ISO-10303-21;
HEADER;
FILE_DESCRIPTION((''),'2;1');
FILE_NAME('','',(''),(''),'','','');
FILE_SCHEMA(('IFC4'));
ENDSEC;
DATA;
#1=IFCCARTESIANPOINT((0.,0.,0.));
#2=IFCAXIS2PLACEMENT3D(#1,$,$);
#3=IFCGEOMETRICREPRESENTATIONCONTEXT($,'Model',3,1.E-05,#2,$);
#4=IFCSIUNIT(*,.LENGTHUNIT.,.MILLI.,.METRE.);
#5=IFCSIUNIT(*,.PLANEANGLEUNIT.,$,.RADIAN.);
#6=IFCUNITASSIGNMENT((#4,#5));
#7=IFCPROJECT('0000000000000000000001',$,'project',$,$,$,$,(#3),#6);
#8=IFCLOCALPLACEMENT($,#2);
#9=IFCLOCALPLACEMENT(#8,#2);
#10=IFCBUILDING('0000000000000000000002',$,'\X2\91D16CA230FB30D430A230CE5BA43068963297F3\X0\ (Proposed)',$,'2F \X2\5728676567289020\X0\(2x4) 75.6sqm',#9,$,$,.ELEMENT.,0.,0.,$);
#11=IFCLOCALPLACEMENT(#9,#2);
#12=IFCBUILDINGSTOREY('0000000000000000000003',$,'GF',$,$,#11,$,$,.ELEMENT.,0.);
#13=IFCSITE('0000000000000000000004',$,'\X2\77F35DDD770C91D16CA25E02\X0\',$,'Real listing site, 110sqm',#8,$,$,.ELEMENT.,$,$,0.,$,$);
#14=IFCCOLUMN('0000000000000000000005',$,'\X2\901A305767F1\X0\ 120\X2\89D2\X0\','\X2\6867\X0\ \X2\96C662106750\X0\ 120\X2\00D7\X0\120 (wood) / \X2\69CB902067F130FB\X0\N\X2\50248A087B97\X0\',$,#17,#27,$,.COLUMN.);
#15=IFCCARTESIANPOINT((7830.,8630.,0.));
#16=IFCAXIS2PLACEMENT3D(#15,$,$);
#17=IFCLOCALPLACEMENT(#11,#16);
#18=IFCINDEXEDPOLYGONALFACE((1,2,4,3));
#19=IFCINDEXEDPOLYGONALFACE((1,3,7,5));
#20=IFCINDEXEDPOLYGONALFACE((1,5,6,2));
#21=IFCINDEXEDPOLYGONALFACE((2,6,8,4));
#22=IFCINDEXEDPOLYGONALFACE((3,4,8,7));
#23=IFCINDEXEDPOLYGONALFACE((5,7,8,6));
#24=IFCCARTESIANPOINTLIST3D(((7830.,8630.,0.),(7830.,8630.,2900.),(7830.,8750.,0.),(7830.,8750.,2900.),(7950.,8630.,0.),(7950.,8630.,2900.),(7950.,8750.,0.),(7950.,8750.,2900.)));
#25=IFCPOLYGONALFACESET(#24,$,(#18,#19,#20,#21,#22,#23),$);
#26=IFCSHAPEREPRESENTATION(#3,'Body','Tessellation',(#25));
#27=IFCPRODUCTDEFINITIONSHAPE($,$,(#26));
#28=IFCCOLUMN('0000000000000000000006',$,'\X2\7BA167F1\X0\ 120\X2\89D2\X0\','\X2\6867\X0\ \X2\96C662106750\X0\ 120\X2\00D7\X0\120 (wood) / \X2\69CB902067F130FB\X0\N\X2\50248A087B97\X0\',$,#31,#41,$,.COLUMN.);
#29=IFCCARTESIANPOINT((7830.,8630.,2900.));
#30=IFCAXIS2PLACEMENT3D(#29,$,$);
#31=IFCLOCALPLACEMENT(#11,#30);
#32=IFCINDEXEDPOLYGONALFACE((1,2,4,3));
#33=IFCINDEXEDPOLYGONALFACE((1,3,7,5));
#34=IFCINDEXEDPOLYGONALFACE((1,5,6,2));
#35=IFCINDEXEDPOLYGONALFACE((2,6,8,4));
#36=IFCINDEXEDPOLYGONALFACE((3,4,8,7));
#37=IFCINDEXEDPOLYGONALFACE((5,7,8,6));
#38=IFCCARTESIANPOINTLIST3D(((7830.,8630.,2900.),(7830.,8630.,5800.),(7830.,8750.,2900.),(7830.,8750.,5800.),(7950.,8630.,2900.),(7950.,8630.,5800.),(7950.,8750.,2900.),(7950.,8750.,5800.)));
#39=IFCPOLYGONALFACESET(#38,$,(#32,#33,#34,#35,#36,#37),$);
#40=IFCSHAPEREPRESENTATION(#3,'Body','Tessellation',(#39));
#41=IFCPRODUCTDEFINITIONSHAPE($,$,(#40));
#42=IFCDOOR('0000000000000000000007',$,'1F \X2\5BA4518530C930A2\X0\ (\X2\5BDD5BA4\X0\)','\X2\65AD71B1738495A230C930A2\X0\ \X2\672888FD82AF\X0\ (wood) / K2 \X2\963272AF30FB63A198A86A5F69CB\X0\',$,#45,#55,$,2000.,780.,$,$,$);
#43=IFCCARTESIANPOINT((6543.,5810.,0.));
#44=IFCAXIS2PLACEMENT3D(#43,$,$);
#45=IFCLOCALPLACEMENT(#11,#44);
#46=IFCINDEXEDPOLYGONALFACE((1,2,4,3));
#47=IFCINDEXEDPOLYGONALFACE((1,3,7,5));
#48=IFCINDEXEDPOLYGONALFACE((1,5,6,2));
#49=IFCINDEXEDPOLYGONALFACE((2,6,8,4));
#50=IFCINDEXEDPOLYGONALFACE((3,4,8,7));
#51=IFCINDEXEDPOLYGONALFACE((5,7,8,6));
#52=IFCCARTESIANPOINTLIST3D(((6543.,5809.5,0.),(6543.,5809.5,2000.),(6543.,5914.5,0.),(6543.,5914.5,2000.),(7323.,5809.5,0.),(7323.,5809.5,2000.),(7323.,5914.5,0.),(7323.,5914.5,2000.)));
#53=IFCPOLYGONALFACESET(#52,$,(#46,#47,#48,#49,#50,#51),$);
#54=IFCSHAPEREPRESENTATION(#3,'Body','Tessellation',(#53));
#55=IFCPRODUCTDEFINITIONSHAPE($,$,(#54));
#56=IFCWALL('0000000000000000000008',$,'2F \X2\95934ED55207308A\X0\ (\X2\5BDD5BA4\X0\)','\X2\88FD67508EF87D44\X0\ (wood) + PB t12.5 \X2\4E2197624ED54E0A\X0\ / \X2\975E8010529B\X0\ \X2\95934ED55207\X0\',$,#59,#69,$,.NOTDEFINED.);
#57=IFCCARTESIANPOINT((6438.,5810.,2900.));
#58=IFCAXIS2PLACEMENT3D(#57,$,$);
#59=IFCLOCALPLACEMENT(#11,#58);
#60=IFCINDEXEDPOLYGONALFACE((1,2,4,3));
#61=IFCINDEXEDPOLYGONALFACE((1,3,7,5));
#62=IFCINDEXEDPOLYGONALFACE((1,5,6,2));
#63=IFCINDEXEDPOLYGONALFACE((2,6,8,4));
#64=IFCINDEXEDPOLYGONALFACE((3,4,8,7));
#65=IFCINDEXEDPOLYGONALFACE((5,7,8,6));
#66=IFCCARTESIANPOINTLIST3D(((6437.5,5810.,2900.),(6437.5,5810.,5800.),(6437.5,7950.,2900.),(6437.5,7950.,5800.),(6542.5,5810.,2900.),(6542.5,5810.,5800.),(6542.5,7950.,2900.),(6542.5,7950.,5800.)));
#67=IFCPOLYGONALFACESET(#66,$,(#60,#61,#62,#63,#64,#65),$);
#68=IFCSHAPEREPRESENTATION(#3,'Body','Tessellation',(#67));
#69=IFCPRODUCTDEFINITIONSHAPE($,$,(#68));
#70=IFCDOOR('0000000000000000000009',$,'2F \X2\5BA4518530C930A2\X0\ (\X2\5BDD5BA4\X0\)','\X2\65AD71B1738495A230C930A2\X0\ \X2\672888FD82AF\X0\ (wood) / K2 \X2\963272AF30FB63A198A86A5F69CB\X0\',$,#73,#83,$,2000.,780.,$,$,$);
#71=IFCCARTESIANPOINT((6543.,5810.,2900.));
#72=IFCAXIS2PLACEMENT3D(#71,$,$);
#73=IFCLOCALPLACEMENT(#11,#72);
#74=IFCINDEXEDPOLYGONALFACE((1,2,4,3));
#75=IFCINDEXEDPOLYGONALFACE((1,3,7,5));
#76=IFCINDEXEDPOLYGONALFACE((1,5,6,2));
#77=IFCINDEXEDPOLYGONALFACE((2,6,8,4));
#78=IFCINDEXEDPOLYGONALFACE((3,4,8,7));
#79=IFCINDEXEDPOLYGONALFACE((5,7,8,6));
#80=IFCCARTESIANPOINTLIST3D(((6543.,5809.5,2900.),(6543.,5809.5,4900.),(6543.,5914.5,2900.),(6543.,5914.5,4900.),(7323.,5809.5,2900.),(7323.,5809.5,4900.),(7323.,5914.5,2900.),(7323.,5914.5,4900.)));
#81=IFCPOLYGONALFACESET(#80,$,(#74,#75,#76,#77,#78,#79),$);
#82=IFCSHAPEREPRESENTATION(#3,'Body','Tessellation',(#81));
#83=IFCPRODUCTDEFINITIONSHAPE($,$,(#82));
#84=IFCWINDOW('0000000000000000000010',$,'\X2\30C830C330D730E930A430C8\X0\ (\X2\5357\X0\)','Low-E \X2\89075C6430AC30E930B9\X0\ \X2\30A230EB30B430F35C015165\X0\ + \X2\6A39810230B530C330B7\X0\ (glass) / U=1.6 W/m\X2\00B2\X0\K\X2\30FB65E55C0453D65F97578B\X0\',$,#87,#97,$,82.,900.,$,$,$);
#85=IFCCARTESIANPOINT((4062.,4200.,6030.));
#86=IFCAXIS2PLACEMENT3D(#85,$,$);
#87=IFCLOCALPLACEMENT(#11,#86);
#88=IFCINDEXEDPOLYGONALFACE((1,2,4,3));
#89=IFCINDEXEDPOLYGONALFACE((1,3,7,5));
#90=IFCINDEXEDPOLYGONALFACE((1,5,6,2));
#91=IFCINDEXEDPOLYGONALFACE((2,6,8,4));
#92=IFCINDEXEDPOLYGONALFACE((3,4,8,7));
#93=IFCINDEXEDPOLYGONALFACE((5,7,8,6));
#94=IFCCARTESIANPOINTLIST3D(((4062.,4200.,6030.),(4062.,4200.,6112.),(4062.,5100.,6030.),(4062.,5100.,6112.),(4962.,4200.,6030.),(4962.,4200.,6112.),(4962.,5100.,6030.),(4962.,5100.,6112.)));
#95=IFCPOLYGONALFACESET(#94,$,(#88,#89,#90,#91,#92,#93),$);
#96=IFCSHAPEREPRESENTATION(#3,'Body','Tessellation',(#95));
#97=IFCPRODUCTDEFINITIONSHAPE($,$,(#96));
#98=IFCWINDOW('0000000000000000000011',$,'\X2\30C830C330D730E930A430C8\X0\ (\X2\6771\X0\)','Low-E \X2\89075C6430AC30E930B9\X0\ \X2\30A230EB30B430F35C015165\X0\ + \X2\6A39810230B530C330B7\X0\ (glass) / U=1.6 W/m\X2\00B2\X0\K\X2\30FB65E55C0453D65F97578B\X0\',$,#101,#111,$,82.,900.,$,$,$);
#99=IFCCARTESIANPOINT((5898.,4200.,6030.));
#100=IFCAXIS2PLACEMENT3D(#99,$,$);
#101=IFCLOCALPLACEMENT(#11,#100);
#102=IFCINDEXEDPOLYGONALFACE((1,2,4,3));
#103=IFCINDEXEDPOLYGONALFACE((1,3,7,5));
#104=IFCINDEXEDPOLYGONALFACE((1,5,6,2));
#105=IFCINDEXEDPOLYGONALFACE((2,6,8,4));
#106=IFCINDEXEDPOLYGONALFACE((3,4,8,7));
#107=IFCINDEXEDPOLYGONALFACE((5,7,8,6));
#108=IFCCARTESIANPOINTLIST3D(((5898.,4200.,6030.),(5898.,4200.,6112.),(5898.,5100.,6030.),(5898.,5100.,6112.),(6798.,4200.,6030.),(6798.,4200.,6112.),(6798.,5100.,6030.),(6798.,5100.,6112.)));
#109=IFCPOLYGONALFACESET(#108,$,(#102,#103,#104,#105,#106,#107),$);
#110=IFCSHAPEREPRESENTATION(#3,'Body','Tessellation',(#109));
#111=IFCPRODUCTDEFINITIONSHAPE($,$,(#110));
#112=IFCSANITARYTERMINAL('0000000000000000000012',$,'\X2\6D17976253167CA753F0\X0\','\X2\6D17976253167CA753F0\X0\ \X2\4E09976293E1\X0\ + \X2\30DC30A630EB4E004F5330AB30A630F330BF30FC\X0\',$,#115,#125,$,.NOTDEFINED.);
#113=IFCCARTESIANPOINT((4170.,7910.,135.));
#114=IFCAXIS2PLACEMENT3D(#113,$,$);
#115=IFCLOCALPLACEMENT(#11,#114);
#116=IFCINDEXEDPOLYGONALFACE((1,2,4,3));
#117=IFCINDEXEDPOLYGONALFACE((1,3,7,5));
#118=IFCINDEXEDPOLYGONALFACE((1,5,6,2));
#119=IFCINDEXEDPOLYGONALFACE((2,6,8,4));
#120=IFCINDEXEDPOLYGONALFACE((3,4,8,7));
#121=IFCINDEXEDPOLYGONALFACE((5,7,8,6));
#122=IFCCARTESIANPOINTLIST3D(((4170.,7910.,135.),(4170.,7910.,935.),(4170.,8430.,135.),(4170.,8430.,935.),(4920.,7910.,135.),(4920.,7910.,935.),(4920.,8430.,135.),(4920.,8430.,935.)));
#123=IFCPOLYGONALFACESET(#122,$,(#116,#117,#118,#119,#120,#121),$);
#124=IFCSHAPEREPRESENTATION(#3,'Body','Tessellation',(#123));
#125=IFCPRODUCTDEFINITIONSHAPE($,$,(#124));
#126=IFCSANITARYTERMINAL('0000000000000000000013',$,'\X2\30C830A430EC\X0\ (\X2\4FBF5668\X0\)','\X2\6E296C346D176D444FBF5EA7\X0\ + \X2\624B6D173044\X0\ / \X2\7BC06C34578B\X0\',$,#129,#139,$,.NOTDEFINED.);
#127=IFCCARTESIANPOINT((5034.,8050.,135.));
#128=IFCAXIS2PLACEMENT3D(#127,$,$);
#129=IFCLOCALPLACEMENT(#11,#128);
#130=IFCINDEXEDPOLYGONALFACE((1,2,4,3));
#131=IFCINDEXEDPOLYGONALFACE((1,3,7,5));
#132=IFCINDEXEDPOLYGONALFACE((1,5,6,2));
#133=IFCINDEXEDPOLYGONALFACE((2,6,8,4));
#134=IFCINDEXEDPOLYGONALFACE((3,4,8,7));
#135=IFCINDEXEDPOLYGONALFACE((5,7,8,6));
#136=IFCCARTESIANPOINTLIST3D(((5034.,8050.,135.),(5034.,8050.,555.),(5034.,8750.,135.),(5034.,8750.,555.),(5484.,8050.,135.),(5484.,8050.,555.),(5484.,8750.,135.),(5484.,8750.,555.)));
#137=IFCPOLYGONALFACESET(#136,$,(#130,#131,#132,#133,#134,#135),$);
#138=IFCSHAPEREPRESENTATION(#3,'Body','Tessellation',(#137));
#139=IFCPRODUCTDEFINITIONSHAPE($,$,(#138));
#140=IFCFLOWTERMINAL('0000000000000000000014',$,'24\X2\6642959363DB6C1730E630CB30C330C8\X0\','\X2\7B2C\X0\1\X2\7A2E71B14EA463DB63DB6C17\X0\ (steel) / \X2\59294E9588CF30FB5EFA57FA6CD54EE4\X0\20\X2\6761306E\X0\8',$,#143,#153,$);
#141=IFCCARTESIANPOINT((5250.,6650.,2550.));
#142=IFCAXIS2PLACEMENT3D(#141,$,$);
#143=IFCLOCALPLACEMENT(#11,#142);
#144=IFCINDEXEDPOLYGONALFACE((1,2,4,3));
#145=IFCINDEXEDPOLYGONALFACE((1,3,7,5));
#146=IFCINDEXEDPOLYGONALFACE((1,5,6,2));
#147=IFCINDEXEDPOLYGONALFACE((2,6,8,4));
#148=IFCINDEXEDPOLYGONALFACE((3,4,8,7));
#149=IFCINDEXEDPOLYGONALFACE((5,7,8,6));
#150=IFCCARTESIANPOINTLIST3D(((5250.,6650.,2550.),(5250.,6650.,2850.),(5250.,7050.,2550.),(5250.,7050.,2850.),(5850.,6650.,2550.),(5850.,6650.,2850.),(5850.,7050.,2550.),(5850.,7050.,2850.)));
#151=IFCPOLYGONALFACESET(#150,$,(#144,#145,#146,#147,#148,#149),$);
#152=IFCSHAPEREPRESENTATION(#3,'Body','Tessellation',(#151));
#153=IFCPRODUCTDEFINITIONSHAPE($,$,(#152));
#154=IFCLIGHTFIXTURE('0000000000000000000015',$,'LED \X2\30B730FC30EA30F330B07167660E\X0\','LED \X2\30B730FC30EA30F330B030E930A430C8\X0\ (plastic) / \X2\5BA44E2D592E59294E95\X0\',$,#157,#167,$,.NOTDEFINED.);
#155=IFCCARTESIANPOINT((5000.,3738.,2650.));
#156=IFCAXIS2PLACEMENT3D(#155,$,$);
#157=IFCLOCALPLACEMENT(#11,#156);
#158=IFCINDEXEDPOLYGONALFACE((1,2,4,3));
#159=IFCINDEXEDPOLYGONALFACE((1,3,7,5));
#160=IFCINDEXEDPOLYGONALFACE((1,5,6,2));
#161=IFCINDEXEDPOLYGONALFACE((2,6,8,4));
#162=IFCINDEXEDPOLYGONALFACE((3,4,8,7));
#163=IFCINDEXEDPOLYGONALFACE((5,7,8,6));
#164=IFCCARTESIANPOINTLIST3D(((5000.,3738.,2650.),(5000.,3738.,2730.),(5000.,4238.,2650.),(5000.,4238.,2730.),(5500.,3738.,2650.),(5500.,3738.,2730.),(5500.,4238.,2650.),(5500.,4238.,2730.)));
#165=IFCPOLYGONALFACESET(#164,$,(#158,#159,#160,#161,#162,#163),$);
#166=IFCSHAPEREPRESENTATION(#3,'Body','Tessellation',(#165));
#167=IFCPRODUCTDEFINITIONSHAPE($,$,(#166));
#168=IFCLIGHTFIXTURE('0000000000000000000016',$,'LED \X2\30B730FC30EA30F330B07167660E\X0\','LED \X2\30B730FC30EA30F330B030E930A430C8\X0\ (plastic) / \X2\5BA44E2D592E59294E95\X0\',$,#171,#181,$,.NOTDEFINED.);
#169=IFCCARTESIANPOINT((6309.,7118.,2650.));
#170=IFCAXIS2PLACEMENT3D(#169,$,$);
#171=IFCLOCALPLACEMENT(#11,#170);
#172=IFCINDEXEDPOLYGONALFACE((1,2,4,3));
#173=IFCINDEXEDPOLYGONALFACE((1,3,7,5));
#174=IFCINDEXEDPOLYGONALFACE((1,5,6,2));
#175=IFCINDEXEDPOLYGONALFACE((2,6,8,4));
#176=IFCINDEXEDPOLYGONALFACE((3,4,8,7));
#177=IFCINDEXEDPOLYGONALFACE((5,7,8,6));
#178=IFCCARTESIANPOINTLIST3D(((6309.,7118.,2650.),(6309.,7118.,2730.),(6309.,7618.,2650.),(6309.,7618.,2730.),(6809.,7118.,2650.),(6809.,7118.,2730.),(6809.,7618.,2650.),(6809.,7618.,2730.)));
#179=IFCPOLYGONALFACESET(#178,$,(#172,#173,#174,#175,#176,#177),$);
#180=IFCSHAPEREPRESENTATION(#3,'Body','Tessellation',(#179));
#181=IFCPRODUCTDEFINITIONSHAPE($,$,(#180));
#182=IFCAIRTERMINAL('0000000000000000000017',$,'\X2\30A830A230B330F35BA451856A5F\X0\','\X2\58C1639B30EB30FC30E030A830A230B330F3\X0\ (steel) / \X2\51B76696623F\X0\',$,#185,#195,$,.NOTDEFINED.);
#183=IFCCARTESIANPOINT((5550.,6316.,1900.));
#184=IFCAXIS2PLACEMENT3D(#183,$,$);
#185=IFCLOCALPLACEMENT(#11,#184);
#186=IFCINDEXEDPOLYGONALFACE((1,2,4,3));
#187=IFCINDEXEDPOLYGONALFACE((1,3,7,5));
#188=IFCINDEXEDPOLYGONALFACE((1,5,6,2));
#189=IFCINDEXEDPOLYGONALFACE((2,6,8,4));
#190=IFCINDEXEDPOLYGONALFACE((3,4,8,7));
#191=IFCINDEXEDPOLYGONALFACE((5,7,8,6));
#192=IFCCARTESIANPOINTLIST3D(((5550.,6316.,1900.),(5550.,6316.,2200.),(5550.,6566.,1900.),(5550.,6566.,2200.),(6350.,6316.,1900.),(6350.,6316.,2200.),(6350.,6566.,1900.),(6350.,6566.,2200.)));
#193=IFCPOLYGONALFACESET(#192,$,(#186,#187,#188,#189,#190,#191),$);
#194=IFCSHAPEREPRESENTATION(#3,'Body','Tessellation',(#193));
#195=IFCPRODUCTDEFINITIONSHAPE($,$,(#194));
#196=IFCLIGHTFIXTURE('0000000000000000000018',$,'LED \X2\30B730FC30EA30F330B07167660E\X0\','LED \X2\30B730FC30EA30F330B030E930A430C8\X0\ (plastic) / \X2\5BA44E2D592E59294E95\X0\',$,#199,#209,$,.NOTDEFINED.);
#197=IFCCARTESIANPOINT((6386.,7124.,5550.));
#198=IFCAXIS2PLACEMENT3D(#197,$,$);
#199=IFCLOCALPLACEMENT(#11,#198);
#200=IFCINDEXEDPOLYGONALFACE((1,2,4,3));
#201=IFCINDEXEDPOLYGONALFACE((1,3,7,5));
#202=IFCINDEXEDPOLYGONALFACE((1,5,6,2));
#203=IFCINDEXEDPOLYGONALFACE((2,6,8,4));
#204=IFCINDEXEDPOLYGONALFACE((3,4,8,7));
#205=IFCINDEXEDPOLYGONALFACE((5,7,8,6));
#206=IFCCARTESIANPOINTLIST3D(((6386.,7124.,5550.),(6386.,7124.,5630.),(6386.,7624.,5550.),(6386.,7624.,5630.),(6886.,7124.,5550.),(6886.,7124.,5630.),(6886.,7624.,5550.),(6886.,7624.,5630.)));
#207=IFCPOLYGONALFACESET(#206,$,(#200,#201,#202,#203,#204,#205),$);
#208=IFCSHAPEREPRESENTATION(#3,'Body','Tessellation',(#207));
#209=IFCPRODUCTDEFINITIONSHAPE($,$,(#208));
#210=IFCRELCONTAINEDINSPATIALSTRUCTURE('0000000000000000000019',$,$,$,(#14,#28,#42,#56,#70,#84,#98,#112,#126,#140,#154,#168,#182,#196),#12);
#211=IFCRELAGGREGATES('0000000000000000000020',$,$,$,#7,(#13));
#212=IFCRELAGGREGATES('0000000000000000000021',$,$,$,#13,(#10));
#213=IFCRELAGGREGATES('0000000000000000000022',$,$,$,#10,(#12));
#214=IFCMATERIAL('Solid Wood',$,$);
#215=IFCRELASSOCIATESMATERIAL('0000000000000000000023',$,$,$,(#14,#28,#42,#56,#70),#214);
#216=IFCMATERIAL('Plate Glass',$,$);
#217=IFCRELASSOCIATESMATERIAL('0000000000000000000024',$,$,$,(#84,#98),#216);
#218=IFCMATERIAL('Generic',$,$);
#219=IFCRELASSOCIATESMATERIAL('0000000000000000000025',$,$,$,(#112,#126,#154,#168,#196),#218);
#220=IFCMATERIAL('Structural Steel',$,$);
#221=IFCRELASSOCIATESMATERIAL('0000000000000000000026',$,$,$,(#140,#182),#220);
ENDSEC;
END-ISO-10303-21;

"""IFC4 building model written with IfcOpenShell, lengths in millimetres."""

from ifc_helpers import new_model, si_unit, frame, frame_2d, origin, place, context, project, spatial, rectangle, extrude, material, element, save


model = new_model("IFC4")

# Units and contexts
model_context = context("Model", 3, precision=1e-05, world=origin())
ifc_project = project(units=[si_unit("LENGTHUNIT", "METRE", prefix="MILLI"), si_unit("PLANEANGLEUNIT", "RADIAN")], contexts=[model_context])

# Site, building, storey
site_placement = place(None, origin())
site = spatial("IfcSite", under=ifc_project, at=site_placement, Name="石川県金沢市", ObjectType="Real listing site, 110sqm", CompositionType="ELEMENT", RefElevation=0.0)
building_placement = place(site_placement, origin())
building = spatial("IfcBuilding", under=site, at=building_placement, Name="金沢・ピアノ室と防音 (Proposed)", ObjectType="2F 在来木造(2x4) 75.6sqm", CompositionType="ELEMENT", ElevationOfRefHeight=0.0, ElevationOfTerrain=0.0)
storey_placement = place(building_placement, origin())
storey = spatial("IfcBuildingStorey", under=building, at=storey_placement, Name="GF", CompositionType="ELEMENT", Elevation=0.0)

# Columns
ifc_material_1 = material(Name="Solid Wood")
column_1_placement = place(storey_placement, frame((7830.0, 8630.0, 0.0)))
element("IfcColumn", 1, at=column_1_placement, inside=storey, material=ifc_material_1, Name="通し柱 120角", Description="桧 集成材 120×120 (wood) / 構造柱・N値計算", PredefinedType="COLUMN", context=model_context, shape_type="SweptSolid", body=[
    extrude(rectangle(XDim=120.0, YDim=120.0, at=frame_2d((60.0, 60.0))), frame((7830.0, 8630.0, 0.0)), (0.0, 0.0, 1.0), 2900.0),
])
column_2_placement = place(storey_placement, frame((7830.0, 8630.0, 2900.0)))
element("IfcColumn", 2, at=column_2_placement, inside=storey, material=ifc_material_1, Name="管柱 120角", Description="桧 集成材 120×120 (wood) / 構造柱・N値計算", PredefinedType="COLUMN", context=model_context, shape_type="SweptSolid", body=[
    extrude(rectangle(XDim=120.0, YDim=120.0, at=frame_2d((60.0, 60.0))), frame((7830.0, 8630.0, 2900.0)), (0.0, 0.0, 1.0), 2900.0),
])

# Door
door_1_placement = place(storey_placement, frame((6543.0, 5810.0, 0.0)))
element("IfcDoor", 3, at=door_1_placement, inside=storey, material=ifc_material_1, Name="1F 室内ドア (寝室)", Description="断熱玄関ドア 木製芯 (wood) / K2 防犯・採風機構", OverallHeight=2000.0, OverallWidth=780.0, context=model_context, shape_type="SweptSolid", body=[
    extrude(rectangle(XDim=780.0, YDim=105.0, at=frame_2d((390.0, 52.0))), frame((6543.0, 5810.0, 0.0)), (0.0, 0.0, 1.0), 2000.0),
])

# Wall
wall_1_placement = place(storey_placement, frame((6438.0, 5810.0, 2900.0)))
element("IfcWall", 4, at=wall_1_placement, inside=storey, material=ifc_material_1, Name="2F 間仕切り (寝室)", Description="製材軸組 (wood) + PB t12.5 両面仕上 / 非耐力 間仕切", PredefinedType="NOTDEFINED", context=model_context, shape_type="SweptSolid", body=[
    extrude(rectangle(XDim=105.0, YDim=2140.0, at=frame_2d((52.0, 1070.0))), frame((6438.0, 5810.0, 2900.0)), (0.0, 0.0, 1.0), 2900.0),
])

# Door
door_2_placement = place(storey_placement, frame((6543.0, 5810.0, 2900.0)))
element("IfcDoor", 5, at=door_2_placement, inside=storey, material=ifc_material_1, Name="2F 室内ドア (寝室)", Description="断熱玄関ドア 木製芯 (wood) / K2 防犯・採風機構", OverallHeight=2000.0, OverallWidth=780.0, context=model_context, shape_type="SweptSolid", body=[
    extrude(rectangle(XDim=780.0, YDim=105.0, at=frame_2d((390.0, 52.0))), frame((6543.0, 5810.0, 2900.0)), (0.0, 0.0, 1.0), 2000.0),
])

# Windows
ifc_material_2 = material(Name="Plate Glass")
window_1_placement = place(storey_placement, frame((4062.0, 4200.0, 6030.0)))
element("IfcWindow", 6, at=window_1_placement, inside=storey, material=ifc_material_2, Name="トップライト (南)", Description="Low-E 複層ガラス アルゴン封入 + 樹脂サッシ (glass) / U=1.6 W/m²K・日射取得型", OverallHeight=82.0, OverallWidth=900.0, context=model_context, shape_type="SweptSolid", body=[
    extrude(rectangle(XDim=900.0, YDim=900.0, at=frame_2d((450.0, 450.0))), frame((4062.0, 4200.0, 6030.0)), (0.0, 0.0, 1.0), 82.0),
])
window_2_placement = place(storey_placement, frame((5898.0, 4200.0, 6030.0)))
element("IfcWindow", 7, at=window_2_placement, inside=storey, material=ifc_material_2, Name="トップライト (東)", Description="Low-E 複層ガラス アルゴン封入 + 樹脂サッシ (glass) / U=1.6 W/m²K・日射取得型", OverallHeight=82.0, OverallWidth=900.0, context=model_context, shape_type="SweptSolid", body=[
    extrude(rectangle(XDim=900.0, YDim=900.0, at=frame_2d((450.0, 450.0))), frame((5898.0, 4200.0, 6030.0)), (0.0, 0.0, 1.0), 82.0),
])

# Sanitary terminals
ifc_material_3 = material(Name="Generic")
sanitary_terminal_1_placement = place(storey_placement, frame((4170.0, 7910.0, 135.0)))
element("IfcSanitaryTerminal", 8, at=sanitary_terminal_1_placement, inside=storey, material=ifc_material_3, Name="洗面化粧台", Description="洗面化粧台 三面鏡 + ボウル一体カウンター", PredefinedType="NOTDEFINED", context=model_context, shape_type="SweptSolid", body=[
    extrude(rectangle(XDim=750.0, YDim=520.0, at=frame_2d((375.0, 260.0))), frame((4170.0, 7910.0, 135.0)), (0.0, 0.0, 1.0), 800.0),
])
sanitary_terminal_2_placement = place(storey_placement, frame((5034.0, 8050.0, 135.0)))
element("IfcSanitaryTerminal", 9, at=sanitary_terminal_2_placement, inside=storey, material=ifc_material_3, Name="トイレ (便器)", Description="温水洗浄便座 + 手洗い / 節水型", PredefinedType="NOTDEFINED", context=model_context, shape_type="SweptSolid", body=[
    extrude(rectangle(XDim=450.0, YDim=700.0, at=frame_2d((225.0, 350.0))), frame((5034.0, 8050.0, 135.0)), (0.0, 0.0, 1.0), 420.0),
])

# Flow terminal
ifc_material_4 = material(Name="Structural Steel")
flow_terminal_placement = place(storey_placement, frame((5250.0, 6650.0, 2550.0)))
element("IfcFlowTerminal", 10, at=flow_terminal_placement, inside=storey, material=ifc_material_4, Name="24時間換気ユニット", Description="第1種熱交換換気 (steel) / 天井裏・建基法令20条の8", context=model_context, shape_type="SweptSolid", body=[
    extrude(rectangle(XDim=600.0, YDim=400.0, at=frame_2d((300.0, 200.0))), frame((5250.0, 6650.0, 2550.0)), (0.0, 0.0, 1.0), 300.0),
])

# Light fixtures
light_fixture_1_placement = place(storey_placement, frame((5000.0, 3738.0, 2650.0)))
element("IfcLightFixture", 11, at=light_fixture_1_placement, inside=storey, material=ifc_material_3, Name="LED シーリング照明", Description="LED シーリングライト (plastic) / 室中央天井", PredefinedType="NOTDEFINED", context=model_context, shape_type="SweptSolid", body=[
    extrude(rectangle(XDim=500.0, YDim=500.0, at=frame_2d((250.0, 250.0))), frame((5000.0, 3738.0, 2650.0)), (0.0, 0.0, 1.0), 80.0),
])
light_fixture_2_placement = place(storey_placement, frame((6309.0, 7118.0, 2650.0)))
element("IfcLightFixture", 12, at=light_fixture_2_placement, inside=storey, material=ifc_material_3, Name="LED シーリング照明", Description="LED シーリングライト (plastic) / 室中央天井", PredefinedType="NOTDEFINED", context=model_context, shape_type="SweptSolid", body=[
    extrude(rectangle(XDim=500.0, YDim=500.0, at=frame_2d((250.0, 250.0))), frame((6309.0, 7118.0, 2650.0)), (0.0, 0.0, 1.0), 80.0),
])

# Air terminal
air_terminal_placement = place(storey_placement, frame((5550.0, 6316.0, 1900.0)))
element("IfcAirTerminal", 13, at=air_terminal_placement, inside=storey, material=ifc_material_4, Name="エアコン室内機", Description="壁掛ルームエアコン (steel) / 冷暖房", PredefinedType="NOTDEFINED", context=model_context, shape_type="SweptSolid", body=[
    extrude(rectangle(XDim=800.0, YDim=250.0, at=frame_2d((400.0, 125.0))), frame((5550.0, 6316.0, 1900.0)), (0.0, 0.0, 1.0), 300.0),
])

# Light fixture
light_fixture_3_placement = place(storey_placement, frame((6386.0, 7124.0, 5550.0)))
element("IfcLightFixture", 14, at=light_fixture_3_placement, inside=storey, material=ifc_material_3, Name="LED シーリング照明", Description="LED シーリングライト (plastic) / 室中央天井", PredefinedType="NOTDEFINED", context=model_context, shape_type="SweptSolid", body=[
    extrude(rectangle(XDim=500.0, YDim=500.0, at=frame_2d((250.0, 250.0))), frame((6386.0, 7124.0, 5550.0)), (0.0, 0.0, 1.0), 80.0),
])

save(model, "model.ifc")
